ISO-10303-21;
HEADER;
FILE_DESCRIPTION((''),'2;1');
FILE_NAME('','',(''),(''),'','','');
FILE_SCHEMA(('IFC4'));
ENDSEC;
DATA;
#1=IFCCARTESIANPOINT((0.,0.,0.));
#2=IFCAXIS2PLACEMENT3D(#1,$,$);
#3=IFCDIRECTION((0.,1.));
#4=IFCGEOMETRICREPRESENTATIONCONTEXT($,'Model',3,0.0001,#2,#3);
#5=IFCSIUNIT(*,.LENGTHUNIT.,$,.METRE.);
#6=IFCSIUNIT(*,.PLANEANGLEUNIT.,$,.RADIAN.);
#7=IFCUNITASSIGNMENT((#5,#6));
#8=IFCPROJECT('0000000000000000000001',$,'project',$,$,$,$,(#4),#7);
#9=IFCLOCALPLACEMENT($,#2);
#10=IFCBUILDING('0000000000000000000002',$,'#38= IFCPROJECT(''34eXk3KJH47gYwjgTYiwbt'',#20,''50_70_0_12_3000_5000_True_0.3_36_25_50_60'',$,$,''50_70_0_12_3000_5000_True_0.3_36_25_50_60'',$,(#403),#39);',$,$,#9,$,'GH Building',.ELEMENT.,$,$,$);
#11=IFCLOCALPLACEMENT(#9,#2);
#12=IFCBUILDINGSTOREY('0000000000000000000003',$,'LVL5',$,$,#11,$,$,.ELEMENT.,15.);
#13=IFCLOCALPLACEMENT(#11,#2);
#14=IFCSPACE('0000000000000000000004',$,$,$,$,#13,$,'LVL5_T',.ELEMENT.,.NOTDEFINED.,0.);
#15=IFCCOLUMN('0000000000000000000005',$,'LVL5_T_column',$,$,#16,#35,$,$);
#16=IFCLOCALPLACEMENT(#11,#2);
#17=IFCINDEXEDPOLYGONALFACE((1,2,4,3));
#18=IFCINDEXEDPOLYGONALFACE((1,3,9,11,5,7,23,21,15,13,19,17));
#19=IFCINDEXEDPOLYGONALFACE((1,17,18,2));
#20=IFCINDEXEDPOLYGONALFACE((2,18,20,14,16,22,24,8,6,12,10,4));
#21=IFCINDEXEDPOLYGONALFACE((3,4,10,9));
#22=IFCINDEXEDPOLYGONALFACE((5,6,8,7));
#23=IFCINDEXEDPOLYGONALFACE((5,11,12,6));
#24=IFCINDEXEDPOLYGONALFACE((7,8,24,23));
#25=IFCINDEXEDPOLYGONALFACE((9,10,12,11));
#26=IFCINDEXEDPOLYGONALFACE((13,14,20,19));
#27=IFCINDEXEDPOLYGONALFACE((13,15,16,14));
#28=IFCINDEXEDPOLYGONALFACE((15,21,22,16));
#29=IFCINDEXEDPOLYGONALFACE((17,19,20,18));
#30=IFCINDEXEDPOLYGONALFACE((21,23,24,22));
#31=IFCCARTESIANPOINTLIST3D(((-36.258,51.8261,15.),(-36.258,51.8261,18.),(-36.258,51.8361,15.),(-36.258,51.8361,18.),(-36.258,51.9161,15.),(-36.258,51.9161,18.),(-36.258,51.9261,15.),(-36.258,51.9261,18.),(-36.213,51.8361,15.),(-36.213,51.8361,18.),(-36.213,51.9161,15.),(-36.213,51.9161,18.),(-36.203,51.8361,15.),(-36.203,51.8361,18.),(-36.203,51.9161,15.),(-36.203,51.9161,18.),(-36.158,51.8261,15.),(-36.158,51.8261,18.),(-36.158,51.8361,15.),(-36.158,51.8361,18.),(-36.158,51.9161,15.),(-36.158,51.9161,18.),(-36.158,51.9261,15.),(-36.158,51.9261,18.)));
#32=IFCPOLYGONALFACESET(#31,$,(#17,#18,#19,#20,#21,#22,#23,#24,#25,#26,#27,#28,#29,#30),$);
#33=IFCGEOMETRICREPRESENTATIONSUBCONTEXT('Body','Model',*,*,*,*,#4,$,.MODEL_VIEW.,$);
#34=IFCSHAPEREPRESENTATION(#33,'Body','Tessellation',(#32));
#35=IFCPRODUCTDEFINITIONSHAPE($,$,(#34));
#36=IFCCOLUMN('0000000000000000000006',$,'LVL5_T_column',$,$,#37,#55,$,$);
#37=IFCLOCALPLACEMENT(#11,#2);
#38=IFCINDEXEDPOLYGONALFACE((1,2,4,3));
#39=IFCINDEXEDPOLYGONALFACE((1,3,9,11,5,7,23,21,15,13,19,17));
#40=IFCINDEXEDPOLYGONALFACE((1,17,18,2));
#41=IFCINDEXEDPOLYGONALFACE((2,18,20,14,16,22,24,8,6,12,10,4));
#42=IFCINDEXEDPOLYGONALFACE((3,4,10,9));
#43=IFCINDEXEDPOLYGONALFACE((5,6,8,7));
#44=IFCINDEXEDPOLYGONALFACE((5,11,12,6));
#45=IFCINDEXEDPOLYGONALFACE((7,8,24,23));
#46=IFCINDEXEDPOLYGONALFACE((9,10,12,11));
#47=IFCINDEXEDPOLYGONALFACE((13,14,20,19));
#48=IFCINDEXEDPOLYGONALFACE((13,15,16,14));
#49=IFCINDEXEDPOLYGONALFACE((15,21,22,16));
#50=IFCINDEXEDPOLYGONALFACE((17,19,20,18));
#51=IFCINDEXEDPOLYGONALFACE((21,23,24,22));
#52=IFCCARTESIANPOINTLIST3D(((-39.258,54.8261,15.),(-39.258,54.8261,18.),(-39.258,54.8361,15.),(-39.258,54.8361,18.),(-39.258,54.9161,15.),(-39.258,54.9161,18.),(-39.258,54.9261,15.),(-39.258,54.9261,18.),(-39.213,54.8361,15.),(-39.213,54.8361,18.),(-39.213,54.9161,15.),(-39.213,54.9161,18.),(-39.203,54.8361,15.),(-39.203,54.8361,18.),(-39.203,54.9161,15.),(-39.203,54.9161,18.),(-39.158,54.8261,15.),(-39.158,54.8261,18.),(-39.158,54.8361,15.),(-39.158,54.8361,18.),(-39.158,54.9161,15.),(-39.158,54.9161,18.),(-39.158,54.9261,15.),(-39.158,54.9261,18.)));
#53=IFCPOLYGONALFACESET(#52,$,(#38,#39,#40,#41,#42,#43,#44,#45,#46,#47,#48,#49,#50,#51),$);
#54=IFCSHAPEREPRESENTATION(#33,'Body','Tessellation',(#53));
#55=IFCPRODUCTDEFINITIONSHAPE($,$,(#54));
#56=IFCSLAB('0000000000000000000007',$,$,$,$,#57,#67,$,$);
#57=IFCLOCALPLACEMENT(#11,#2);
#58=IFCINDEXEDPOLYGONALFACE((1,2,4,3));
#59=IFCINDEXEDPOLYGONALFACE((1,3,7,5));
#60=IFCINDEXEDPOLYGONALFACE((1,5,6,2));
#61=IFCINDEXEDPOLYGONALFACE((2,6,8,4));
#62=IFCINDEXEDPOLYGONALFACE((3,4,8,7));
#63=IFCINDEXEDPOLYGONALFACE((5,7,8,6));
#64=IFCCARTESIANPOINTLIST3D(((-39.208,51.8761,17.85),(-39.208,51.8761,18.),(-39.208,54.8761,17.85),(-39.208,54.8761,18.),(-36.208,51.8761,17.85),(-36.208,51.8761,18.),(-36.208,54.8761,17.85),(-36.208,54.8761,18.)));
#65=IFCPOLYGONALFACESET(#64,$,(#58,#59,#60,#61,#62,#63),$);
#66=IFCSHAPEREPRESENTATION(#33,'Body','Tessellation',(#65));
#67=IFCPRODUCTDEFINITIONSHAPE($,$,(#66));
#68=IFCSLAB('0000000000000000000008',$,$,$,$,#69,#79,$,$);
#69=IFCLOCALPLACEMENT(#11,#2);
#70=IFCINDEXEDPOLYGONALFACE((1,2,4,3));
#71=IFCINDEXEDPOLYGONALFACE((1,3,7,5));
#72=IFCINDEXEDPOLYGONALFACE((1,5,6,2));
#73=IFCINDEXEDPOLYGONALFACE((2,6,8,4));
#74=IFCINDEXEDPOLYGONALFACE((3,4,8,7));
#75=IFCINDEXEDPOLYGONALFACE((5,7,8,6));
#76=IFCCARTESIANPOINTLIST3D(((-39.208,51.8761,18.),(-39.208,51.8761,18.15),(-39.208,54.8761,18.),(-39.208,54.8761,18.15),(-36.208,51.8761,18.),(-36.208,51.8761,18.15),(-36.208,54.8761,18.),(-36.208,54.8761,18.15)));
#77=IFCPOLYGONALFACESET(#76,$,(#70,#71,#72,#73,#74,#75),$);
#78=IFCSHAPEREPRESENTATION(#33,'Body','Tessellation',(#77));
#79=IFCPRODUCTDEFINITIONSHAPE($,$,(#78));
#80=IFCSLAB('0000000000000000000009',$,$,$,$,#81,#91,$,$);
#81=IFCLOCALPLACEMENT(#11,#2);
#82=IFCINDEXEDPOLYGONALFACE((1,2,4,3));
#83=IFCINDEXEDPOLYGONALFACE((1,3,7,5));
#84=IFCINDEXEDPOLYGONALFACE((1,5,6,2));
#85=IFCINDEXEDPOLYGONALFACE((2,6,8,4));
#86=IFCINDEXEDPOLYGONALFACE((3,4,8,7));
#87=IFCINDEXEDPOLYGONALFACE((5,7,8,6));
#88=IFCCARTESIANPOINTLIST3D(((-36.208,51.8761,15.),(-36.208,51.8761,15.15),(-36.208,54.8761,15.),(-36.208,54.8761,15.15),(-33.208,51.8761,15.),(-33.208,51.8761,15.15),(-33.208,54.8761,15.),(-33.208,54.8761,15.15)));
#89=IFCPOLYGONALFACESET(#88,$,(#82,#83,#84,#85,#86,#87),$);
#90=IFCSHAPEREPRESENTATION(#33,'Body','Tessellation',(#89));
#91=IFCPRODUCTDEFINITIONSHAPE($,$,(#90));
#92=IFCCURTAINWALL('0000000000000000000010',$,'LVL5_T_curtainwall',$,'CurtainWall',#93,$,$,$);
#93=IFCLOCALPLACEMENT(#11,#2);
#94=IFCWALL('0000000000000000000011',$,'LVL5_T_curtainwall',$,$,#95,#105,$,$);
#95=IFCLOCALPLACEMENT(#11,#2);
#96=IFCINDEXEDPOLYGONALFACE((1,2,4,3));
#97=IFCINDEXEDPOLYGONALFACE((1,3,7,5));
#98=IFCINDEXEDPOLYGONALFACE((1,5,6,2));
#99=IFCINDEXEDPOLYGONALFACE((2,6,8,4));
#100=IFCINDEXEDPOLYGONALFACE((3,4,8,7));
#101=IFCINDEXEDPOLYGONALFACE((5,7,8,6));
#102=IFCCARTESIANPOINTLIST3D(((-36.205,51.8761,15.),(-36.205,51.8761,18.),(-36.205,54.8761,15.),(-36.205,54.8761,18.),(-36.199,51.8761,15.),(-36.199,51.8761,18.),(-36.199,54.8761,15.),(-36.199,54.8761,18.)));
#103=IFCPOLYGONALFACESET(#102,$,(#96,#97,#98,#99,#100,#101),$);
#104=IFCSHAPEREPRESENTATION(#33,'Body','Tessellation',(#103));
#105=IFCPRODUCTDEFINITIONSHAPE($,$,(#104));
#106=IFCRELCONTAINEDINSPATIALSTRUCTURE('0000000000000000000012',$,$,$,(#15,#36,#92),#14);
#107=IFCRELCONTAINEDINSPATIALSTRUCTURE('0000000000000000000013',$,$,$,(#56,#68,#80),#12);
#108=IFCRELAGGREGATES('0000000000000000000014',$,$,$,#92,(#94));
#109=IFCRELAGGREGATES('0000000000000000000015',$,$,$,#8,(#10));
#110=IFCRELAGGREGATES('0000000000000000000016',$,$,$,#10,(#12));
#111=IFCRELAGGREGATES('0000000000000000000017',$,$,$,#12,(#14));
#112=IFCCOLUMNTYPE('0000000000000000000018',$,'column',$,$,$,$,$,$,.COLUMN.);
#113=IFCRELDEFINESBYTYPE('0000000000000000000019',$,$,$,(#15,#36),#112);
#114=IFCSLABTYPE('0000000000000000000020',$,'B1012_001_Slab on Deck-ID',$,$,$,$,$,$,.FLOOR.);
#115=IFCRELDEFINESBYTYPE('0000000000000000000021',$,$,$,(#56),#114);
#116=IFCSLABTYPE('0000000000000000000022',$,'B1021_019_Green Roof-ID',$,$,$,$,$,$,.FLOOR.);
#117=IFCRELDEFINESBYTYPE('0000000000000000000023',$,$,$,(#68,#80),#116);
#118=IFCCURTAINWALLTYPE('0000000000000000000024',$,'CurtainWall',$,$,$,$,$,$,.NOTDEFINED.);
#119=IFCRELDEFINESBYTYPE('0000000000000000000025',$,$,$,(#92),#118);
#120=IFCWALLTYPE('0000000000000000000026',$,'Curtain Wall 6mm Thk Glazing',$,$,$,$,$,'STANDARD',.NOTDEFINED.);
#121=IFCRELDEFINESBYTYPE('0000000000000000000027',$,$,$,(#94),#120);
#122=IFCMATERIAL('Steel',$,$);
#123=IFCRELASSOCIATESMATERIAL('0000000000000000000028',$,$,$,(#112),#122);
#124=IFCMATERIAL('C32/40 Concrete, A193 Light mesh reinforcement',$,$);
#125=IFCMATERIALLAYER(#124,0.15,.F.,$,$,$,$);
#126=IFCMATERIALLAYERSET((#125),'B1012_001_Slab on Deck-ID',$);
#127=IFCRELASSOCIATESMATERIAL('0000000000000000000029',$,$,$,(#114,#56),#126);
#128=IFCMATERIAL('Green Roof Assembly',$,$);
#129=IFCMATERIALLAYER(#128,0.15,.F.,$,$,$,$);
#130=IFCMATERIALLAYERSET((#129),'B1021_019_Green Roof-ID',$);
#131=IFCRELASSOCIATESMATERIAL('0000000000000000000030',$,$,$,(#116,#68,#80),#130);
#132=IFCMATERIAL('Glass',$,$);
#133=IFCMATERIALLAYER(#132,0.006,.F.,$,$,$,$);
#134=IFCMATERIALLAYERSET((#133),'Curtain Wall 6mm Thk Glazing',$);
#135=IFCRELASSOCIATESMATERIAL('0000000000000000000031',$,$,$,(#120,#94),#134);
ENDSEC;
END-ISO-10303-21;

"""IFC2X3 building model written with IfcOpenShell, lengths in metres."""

from ifc_helpers import new_model, si_unit, direction, frame, frame_2d, origin, origin_2d, place, context, subcontext, project, spatial, polyline, rectangle, i_section, outline, extrude, material, layer, layer_set, layer_usage, type_object, element, aggregate, save


model = new_model("IFC2X3")

# Units and contexts
model_context = context("Model", 3, precision=0.0001, world=origin(), true_north=direction((0.0, 1.0)))
body_context = subcontext(model_context, "Body", "Model", "MODEL_VIEW")
ifc_project = project(units=[si_unit("LENGTHUNIT", "METRE"), si_unit("PLANEANGLEUNIT", "RADIAN")], contexts=[model_context])

# Building, storey, space
building_placement = place(None, origin())
building = spatial("IfcBuilding", under=ifc_project, at=building_placement, Name="#38= IFCPROJECT('34eXk3KJH47gYwjgTYiwbt',#20,'50_70_0_12_3000_5000_True_0.3_36_25_50_60',$,$,'50_70_0_12_3000_5000_True_0.3_36_25_50_60',$,(#403),#39);", LongName="GH Building", CompositionType="ELEMENT")
storey_placement = place(building_placement, origin())
storey = spatial("IfcBuildingStorey", under=building, at=storey_placement, Name="LVL5", CompositionType="ELEMENT", Elevation=15.0)
space_1_placement = place(storey_placement, origin())
space_1 = spatial("IfcSpace", under=storey, at=space_1_placement, LongName="LVL5_T", CompositionType="ELEMENT", InteriorOrExteriorSpace="NOTDEFINED", ElevationWithFlooring=0.0)

# Columns
ifc_material_1 = material(Name="Steel")
column_type = type_object("IfcColumnType", Name="column", PredefinedType="COLUMN", material=ifc_material_1)
for number, where, name in (
    (1, (-36.208, 51.8761, 15.0), "LVL5_T_column"),
    (2, (-39.208, 54.8761, 15.0), "LVL5_T_column"),
):
    element("IfcColumn", number, at=place(space_1_placement, frame(where)), inside=space_1, type_object=column_type, Name=name, context=body_context, shape_type="SweptSolid", body=[
        extrude(i_section(OverallWidth=0.1, OverallDepth=0.1, WebThickness=0.01, FlangeThickness=0.01, at=origin_2d()), origin(), (0.0, 0.0, 1.0), 3.0),
    ])

# Slabs
ifc_material_2 = material(Name="C32/40 Concrete, A193 Light mesh reinforcement")
ifc_layer_1 = layer(ifc_material_2, 0.15, ventilated=False)
ifc_layer_set_1 = layer_set([ifc_layer_1], Name="B1012_001_Slab on Deck-ID")
ifc_layer_usage_1 = layer_usage(ifc_layer_set_1, "AXIS3", "NEGATIVE", -0.15)
slab_type_1 = type_object("IfcSlabType", Name="B1012_001_Slab on Deck-ID", PredefinedType="FLOOR", material=ifc_layer_set_1)
slab_1_placement = place(storey_placement, frame((-37.708, 53.3761, 17.85)))
element("IfcSlab", 3, at=slab_1_placement, inside=storey, type_object=slab_type_1, material=ifc_layer_usage_1, context=body_context, shape_type="SweptSolid", body=[
    extrude(outline(polyline([(1.5, -1.5), (-1.5, -1.5), (-1.5, 1.5), (1.5, 1.5), (1.5, -1.5)])), origin(), (0.0, 0.0, 1.0), 0.15),
])
ifc_material_3 = material(Name="Green Roof Assembly")
ifc_layer_2 = layer(ifc_material_3, 0.15, ventilated=False)
ifc_layer_set_2 = layer_set([ifc_layer_2], Name="B1021_019_Green Roof-ID")
ifc_layer_usage_2 = layer_usage(ifc_layer_set_2, "AXIS3", "NEGATIVE", -0.15)
slab_type_2 = type_object("IfcSlabType", Name="B1021_019_Green Roof-ID", PredefinedType="FLOOR", material=ifc_layer_set_2)
slab_2_placement = place(storey_placement, frame((-37.708, 53.3761, 18.0)))
element("IfcSlab", 4, at=slab_2_placement, inside=storey, type_object=slab_type_2, material=ifc_layer_usage_2, context=body_context, shape_type="SweptSolid", body=[
    extrude(outline(polyline([(1.5, -1.5), (-1.5, -1.5), (-1.5, 1.5), (1.5, 1.5), (1.5, -1.5)])), origin(), (0.0, 0.0, 1.0), 0.15),
])
ifc_layer_usage_3 = layer_usage(ifc_layer_set_2, "AXIS3", "NEGATIVE", -0.15)
slab_3_placement = place(storey_placement, frame((-34.708, 53.3761, 15.0)))
element("IfcSlab", 5, at=slab_3_placement, inside=storey, type_object=slab_type_2, material=ifc_layer_usage_3, context=body_context, shape_type="SweptSolid", body=[
    extrude(outline(polyline([(1.5, -1.5), (-1.5, -1.5), (-1.5, 1.5), (1.5, 1.5), (1.5, -1.5)])), origin(), (0.0, 0.0, 1.0), 0.15),
])

# Curtain wall, wall
curtain_wall_type = type_object("IfcCurtainWallType", Name="CurtainWall", PredefinedType="NOTDEFINED")
curtain_wall_1_placement = place(None, origin())
curtain_wall_1 = element("IfcCurtainWall", 6, at=curtain_wall_1_placement, inside=space_1, type_object=curtain_wall_type, Name="LVL5_T_curtainwall", ObjectType="CurtainWall")
ifc_material_4 = material(Name="Glass")
ifc_layer_3 = layer(ifc_material_4, 0.006, ventilated=False)
ifc_layer_set_3 = layer_set([ifc_layer_3], Name="Curtain Wall 6mm Thk Glazing")
ifc_layer_usage_4 = layer_usage(ifc_layer_set_3, "AXIS2", "NEGATIVE", -0.003)
wall_type = type_object("IfcWallType", Name="Curtain Wall 6mm Thk Glazing", ElementType="STANDARD", PredefinedType="NOTDEFINED", material=ifc_layer_set_3)
wall_1_placement = place(curtain_wall_1_placement, frame((-36.208, 51.8761, 15.0), z_axis=(0.0, 0.0, 1.0), x_axis=(0.0, 1.0, 0.0)))
wall_1 = element("IfcWall", 7, at=wall_1_placement, type_object=wall_type, material=ifc_layer_usage_4, Name="LVL5_T_curtainwall", context=body_context, shape_type="SweptSolid", body=[
    extrude(rectangle(XDim=3.0, YDim=0.006, at=frame_2d((1.5, -0.006))), origin(), (0.0, 0.0, 1.0), 3.0),
])
aggregate(curtain_wall_1, [wall_1])

save(model, "model.ifc")
